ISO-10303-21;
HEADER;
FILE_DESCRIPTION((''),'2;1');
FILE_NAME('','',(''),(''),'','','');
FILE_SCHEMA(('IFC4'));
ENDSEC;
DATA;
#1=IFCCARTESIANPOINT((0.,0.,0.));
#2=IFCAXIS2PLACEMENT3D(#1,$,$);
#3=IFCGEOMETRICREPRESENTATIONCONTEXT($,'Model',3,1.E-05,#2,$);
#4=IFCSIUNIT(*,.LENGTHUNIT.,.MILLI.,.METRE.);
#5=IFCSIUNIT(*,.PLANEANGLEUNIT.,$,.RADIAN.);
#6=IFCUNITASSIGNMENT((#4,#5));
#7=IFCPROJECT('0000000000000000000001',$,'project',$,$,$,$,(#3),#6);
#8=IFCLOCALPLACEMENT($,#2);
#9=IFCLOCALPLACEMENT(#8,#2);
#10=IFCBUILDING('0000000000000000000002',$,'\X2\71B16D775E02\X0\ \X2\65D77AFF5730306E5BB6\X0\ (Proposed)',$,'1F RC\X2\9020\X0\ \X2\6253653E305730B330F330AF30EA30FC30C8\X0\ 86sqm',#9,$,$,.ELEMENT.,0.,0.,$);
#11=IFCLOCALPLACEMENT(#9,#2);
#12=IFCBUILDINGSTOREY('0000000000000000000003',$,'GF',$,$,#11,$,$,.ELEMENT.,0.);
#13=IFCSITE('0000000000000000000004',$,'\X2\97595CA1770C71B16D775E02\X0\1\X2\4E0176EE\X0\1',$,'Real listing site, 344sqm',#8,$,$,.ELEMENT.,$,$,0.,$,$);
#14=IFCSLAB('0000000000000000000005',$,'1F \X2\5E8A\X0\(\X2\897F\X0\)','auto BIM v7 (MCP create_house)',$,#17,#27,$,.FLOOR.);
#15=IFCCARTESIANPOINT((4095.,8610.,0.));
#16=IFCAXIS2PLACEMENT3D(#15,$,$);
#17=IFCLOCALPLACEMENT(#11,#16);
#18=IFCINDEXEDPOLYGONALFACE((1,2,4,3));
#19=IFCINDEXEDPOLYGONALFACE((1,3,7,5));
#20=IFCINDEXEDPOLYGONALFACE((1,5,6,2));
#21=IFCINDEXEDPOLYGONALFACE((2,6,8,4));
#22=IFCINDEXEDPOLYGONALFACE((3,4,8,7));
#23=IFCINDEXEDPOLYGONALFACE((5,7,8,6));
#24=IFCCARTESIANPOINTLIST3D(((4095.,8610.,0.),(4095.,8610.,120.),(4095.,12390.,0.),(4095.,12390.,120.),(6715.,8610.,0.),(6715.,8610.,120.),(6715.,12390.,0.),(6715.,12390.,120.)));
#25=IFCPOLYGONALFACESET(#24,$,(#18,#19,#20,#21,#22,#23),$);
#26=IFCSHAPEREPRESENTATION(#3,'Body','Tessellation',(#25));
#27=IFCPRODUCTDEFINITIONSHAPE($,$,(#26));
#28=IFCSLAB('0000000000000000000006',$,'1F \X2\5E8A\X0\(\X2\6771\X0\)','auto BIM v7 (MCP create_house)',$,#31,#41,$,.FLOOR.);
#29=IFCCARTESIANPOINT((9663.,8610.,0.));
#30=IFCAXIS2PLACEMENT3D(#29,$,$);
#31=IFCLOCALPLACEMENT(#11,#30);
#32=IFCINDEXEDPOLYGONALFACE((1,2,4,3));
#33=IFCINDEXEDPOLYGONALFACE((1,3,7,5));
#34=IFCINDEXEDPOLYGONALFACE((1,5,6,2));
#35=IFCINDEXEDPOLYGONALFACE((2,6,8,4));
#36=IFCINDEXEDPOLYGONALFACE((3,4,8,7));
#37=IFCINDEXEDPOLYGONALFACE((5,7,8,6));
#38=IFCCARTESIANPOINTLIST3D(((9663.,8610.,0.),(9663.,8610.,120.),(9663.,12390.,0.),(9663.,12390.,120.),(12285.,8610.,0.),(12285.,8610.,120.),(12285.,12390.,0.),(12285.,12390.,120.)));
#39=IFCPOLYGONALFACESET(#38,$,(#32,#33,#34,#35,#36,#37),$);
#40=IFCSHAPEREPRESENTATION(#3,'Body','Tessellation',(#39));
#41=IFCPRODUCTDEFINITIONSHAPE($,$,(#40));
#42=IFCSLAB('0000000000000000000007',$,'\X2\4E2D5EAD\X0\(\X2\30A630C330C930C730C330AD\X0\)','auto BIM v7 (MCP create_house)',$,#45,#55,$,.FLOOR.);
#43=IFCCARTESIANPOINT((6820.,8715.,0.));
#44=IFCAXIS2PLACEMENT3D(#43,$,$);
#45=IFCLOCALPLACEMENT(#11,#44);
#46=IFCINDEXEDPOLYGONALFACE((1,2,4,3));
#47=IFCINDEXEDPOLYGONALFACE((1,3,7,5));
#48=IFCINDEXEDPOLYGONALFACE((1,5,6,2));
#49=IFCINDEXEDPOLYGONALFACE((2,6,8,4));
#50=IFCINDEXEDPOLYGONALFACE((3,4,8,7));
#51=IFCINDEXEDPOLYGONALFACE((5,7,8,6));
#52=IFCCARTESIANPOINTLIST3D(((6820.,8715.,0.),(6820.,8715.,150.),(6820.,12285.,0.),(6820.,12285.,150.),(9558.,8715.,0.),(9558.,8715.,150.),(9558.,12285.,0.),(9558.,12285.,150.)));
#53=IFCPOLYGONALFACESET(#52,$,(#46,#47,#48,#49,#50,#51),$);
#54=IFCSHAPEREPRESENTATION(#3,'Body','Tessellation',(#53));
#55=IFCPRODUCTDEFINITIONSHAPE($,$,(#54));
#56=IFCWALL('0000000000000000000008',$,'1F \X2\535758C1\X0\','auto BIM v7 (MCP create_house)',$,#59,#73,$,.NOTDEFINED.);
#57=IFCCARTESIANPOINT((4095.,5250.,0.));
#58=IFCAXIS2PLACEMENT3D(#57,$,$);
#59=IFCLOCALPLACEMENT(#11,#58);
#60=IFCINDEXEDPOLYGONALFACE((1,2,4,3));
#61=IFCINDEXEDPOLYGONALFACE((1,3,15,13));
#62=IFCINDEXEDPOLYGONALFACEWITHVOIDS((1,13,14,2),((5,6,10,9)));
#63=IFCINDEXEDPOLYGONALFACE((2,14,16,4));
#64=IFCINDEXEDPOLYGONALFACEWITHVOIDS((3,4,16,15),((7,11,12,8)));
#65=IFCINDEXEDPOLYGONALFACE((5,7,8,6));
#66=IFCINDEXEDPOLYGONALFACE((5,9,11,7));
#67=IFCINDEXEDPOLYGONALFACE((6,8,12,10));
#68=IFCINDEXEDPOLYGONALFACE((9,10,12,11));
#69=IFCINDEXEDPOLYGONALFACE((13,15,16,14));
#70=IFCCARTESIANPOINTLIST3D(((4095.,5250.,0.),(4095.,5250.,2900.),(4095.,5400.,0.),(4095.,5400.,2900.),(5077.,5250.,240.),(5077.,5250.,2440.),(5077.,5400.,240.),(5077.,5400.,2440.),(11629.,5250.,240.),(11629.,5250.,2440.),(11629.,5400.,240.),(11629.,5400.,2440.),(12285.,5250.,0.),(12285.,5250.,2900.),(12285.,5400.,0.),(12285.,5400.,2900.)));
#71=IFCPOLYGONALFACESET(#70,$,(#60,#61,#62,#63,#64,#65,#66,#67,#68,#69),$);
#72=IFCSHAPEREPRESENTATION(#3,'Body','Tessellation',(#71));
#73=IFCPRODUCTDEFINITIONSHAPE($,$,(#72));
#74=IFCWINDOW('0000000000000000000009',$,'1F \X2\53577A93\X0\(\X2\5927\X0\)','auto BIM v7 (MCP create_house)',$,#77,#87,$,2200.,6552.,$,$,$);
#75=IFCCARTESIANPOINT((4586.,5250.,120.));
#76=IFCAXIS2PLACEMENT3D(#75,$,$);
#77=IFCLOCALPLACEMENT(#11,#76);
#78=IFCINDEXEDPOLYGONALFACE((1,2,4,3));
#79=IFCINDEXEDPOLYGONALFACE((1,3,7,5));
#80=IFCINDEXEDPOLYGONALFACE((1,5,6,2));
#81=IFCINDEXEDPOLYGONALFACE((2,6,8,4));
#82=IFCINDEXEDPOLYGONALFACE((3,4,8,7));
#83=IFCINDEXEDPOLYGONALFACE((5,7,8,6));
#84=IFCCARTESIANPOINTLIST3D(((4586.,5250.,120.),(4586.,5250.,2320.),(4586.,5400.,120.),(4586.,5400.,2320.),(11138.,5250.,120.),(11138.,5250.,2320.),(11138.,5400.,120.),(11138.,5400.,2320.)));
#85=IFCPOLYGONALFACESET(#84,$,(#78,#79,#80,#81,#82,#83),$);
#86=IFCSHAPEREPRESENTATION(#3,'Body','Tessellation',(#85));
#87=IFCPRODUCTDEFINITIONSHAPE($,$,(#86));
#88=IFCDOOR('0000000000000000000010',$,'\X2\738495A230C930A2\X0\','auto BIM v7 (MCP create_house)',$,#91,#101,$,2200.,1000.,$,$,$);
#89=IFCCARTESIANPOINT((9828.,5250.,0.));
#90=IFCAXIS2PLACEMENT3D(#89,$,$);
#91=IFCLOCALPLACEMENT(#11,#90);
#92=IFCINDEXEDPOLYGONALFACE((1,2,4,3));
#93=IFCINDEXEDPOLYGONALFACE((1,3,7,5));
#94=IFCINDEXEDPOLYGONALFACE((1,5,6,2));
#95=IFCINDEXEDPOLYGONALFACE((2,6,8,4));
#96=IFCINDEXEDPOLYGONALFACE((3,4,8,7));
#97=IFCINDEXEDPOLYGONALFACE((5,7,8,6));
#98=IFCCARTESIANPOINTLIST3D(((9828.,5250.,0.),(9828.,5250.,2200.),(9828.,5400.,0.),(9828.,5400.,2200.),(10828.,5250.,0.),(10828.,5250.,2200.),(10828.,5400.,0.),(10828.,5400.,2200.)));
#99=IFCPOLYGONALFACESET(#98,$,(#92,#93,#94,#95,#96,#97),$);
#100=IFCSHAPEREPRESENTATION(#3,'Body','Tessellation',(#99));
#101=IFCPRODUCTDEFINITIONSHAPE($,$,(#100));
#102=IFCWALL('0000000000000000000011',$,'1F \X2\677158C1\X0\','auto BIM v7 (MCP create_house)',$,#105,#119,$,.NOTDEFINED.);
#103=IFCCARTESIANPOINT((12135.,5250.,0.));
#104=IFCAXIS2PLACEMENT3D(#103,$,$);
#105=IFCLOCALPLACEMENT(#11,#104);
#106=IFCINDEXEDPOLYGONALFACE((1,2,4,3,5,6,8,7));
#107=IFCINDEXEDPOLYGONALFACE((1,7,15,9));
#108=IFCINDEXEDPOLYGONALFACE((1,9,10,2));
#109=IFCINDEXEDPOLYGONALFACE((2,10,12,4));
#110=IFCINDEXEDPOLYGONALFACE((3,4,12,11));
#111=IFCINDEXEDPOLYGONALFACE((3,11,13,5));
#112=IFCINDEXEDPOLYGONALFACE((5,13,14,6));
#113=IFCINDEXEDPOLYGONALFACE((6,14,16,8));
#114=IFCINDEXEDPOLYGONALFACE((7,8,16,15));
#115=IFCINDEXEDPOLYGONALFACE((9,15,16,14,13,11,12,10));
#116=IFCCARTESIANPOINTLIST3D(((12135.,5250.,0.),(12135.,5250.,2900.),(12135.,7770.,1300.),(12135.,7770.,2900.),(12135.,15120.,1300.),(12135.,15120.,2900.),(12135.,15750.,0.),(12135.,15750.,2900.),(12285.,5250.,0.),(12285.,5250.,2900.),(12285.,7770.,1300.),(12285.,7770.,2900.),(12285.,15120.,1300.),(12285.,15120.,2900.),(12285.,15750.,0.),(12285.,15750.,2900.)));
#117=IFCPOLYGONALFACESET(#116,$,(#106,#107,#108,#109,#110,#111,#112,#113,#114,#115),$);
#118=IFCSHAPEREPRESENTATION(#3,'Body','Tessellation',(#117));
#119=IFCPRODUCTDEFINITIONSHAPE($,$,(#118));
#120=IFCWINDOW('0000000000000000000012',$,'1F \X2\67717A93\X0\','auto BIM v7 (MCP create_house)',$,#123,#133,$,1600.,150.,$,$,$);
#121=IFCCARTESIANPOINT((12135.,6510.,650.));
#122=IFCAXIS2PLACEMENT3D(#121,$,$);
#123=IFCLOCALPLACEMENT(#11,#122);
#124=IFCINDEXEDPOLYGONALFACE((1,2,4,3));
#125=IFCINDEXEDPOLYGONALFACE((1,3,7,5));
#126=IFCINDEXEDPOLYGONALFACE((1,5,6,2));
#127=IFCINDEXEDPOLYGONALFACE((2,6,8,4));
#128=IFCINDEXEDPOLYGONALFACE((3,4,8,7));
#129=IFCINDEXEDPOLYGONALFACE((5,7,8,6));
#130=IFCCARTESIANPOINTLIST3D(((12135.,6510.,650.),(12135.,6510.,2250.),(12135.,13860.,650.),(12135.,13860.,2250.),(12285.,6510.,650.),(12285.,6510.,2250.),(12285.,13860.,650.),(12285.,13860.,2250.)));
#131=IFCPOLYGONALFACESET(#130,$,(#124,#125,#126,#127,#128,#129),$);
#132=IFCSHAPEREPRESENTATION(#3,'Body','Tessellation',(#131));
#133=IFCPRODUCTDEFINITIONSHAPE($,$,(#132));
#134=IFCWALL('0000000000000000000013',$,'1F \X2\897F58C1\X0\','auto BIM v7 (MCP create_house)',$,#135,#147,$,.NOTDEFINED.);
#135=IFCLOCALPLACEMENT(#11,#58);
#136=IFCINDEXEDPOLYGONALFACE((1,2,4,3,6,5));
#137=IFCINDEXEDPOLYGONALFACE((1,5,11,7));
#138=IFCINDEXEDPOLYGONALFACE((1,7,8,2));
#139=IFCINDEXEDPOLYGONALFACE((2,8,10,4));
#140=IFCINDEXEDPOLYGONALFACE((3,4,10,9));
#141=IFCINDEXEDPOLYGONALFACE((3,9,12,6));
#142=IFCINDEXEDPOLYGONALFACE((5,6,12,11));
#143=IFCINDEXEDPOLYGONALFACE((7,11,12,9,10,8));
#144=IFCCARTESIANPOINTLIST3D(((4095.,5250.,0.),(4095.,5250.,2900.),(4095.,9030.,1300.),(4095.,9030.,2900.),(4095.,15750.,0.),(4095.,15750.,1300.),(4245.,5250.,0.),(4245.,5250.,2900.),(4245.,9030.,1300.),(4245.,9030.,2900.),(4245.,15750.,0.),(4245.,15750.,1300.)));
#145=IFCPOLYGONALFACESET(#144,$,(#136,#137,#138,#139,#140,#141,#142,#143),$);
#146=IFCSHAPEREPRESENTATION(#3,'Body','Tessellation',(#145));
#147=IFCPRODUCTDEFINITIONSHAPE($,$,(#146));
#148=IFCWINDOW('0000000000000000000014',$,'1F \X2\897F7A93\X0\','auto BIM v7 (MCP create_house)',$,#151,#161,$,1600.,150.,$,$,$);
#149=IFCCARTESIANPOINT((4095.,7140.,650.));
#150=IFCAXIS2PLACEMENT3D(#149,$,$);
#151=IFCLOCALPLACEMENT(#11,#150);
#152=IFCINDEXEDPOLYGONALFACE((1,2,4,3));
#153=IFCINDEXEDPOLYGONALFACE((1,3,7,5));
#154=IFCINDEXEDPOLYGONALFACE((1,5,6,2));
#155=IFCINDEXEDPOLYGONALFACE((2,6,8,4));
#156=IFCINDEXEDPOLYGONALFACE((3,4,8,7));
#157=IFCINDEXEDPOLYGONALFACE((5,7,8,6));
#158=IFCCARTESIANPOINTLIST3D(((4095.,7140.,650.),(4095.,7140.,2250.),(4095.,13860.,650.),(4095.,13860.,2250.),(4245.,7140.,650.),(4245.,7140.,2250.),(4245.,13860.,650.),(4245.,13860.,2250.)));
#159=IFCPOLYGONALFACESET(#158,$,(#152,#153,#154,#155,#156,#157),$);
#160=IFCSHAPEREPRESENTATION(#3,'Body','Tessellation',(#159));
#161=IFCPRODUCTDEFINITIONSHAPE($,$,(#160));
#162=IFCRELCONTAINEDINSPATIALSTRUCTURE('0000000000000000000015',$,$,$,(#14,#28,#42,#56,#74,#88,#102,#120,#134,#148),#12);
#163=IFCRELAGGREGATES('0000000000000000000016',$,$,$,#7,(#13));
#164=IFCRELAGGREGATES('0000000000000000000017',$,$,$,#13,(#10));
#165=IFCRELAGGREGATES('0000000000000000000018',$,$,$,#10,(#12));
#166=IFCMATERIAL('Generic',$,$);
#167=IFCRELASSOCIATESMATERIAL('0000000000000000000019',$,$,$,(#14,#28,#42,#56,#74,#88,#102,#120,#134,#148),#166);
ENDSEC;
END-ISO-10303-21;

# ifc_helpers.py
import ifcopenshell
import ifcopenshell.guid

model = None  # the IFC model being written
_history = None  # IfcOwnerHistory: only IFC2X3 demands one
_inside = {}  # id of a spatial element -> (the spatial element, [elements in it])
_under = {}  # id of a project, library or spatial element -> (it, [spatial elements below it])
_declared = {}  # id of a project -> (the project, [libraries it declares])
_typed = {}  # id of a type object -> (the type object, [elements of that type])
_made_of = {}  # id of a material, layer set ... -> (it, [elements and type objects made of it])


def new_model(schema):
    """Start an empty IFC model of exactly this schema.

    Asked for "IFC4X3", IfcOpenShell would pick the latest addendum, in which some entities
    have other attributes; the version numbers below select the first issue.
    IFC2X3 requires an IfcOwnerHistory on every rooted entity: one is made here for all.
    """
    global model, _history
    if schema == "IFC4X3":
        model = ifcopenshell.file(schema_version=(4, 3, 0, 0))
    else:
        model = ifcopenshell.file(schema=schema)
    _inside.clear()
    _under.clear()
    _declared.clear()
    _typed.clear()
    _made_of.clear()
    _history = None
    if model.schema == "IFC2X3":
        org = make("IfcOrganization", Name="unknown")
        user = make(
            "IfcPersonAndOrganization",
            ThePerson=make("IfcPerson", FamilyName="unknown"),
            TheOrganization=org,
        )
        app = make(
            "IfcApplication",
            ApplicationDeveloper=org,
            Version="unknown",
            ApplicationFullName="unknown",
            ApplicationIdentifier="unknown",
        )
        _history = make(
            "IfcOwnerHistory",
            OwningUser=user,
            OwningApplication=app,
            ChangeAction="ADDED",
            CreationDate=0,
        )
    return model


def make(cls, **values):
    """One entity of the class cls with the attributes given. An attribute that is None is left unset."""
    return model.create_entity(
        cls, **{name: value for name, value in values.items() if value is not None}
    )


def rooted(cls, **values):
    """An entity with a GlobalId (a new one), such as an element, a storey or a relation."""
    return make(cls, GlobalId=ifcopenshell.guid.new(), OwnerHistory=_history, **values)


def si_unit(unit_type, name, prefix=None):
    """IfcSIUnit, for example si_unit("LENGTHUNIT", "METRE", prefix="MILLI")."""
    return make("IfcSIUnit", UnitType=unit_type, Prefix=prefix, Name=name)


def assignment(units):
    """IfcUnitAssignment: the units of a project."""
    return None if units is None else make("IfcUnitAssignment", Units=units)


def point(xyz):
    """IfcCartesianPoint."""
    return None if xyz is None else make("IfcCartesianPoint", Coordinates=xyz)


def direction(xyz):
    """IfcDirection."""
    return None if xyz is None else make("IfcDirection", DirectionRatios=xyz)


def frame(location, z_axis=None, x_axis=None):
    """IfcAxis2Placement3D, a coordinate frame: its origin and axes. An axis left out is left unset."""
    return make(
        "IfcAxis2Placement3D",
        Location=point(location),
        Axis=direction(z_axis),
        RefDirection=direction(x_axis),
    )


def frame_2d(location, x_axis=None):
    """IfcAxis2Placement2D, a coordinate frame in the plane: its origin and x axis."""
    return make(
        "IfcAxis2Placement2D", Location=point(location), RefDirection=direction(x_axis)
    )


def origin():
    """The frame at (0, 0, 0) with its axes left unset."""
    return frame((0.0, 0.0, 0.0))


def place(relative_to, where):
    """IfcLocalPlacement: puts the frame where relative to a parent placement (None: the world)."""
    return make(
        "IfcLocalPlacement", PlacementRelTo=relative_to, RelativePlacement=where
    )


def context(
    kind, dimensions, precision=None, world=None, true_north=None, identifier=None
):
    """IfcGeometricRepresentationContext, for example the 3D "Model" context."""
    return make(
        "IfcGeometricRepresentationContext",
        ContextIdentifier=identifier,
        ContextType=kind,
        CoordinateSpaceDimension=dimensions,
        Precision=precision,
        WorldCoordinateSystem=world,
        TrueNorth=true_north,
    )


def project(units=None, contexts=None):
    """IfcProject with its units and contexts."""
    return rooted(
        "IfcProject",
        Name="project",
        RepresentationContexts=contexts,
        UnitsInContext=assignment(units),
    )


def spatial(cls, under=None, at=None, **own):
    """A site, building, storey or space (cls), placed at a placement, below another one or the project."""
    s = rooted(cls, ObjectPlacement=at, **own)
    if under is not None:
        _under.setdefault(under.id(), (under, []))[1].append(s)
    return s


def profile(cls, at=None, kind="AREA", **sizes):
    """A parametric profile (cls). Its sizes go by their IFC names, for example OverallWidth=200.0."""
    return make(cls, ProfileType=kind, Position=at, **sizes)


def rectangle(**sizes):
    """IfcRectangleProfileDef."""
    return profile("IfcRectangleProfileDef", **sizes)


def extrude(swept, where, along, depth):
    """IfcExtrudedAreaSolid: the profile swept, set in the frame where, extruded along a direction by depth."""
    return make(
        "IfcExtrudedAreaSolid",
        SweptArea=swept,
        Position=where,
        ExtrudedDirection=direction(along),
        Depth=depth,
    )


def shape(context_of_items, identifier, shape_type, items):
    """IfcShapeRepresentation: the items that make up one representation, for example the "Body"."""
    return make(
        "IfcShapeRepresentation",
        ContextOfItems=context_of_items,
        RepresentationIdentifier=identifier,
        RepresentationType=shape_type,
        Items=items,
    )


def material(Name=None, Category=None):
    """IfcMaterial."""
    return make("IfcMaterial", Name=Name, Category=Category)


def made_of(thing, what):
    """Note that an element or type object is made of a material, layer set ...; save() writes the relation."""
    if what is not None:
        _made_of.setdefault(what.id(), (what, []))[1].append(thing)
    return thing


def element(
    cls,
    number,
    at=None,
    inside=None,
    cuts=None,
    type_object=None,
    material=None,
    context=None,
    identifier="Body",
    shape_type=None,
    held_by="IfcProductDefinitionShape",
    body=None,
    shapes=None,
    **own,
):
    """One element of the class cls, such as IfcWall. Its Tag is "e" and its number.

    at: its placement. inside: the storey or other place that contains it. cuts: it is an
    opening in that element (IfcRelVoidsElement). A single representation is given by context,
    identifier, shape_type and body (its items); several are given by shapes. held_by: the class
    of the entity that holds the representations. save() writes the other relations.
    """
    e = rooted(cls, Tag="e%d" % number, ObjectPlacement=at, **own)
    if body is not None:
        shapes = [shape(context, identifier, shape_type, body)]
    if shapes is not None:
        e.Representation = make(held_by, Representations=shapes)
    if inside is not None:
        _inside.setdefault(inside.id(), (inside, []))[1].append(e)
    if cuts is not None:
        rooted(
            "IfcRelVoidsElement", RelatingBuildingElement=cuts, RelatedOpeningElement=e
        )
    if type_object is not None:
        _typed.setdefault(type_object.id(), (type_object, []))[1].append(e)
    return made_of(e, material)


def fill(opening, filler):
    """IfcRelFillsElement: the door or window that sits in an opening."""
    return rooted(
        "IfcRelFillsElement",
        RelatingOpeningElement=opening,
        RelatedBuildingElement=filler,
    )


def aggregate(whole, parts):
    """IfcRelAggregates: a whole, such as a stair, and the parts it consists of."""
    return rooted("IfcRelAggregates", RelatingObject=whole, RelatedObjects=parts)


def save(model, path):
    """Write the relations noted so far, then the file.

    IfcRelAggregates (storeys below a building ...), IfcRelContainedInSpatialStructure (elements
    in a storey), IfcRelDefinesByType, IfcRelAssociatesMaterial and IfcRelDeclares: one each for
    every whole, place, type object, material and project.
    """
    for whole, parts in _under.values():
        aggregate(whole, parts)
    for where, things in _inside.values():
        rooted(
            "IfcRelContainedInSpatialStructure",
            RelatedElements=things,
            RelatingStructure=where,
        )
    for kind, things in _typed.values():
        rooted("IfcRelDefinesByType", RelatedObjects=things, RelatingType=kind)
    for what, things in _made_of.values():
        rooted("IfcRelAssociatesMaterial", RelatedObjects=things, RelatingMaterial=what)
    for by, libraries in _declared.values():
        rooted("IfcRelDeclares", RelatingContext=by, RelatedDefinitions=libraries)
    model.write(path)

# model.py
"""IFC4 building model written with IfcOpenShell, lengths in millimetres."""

from ifc_helpers import new_model, si_unit, frame, frame_2d, origin, place, context, project, spatial, rectangle, extrude, material, element, fill, save


model = new_model("IFC4")

# Units and contexts
model_context = context("Model", 3, precision=1e-05, world=origin())
ifc_project = project(units=[si_unit("LENGTHUNIT", "METRE", prefix="MILLI"), si_unit("PLANEANGLEUNIT", "RADIAN")], contexts=[model_context])

# Site, building, storey
site_placement = place(None, origin())
site = spatial("IfcSite", under=ifc_project, at=site_placement, Name="静岡県熱海市1丁目1", ObjectType="Real listing site, 344sqm", CompositionType="ELEMENT", RefElevation=0.0)
building_placement = place(site_placement, origin())
building = spatial("IfcBuilding", under=site, at=building_placement, Name="熱海市 旗竿地の家 (Proposed)", ObjectType="1F RC造 打放しコンクリート 86sqm", CompositionType="ELEMENT", ElevationOfRefHeight=0.0, ElevationOfTerrain=0.0)
storey_placement = place(building_placement, origin())
storey = spatial("IfcBuildingStorey", under=building, at=storey_placement, Name="GF", CompositionType="ELEMENT", Elevation=0.0)

# Slabs
ifc_material = material(Name="Generic")
slab_1_placement = place(storey_placement, frame((4095.0, 8610.0, 0.0)))
element("IfcSlab", 1, at=slab_1_placement, inside=storey, material=ifc_material, Name="1F 床(西)", Description="auto BIM v7 (MCP create_house)", PredefinedType="FLOOR", context=model_context, shape_type="SweptSolid", body=[
    extrude(rectangle(XDim=2620.0, YDim=3780.0, at=frame_2d((1310.0, 1890.0))), frame((4095.0, 8610.0, 0.0)), (0.0, 0.0, 1.0), 120.0),
])
slab_2_placement = place(storey_placement, frame((9663.0, 8610.0, 0.0)))
element("IfcSlab", 2, at=slab_2_placement, inside=storey, material=ifc_material, Name="1F 床(東)", Description="auto BIM v7 (MCP create_house)", PredefinedType="FLOOR", context=model_context, shape_type="SweptSolid", body=[
    extrude(rectangle(XDim=2622.0, YDim=3780.0, at=frame_2d((1311.0, 1890.0))), frame((9663.0, 8610.0, 0.0)), (0.0, 0.0, 1.0), 120.0),
])
slab_3_placement = place(storey_placement, frame((6820.0, 8715.0, 0.0)))
element("IfcSlab", 3, at=slab_3_placement, inside=storey, material=ifc_material, Name="中庭(ウッドデッキ)", Description="auto BIM v7 (MCP create_house)", PredefinedType="FLOOR", context=model_context, shape_type="SweptSolid", body=[
    extrude(rectangle(XDim=2738.0, YDim=3570.0, at=frame_2d((1369.0, 1785.0))), frame((6820.0, 8715.0, 0.0)), (0.0, 0.0, 1.0), 150.0),
])

# Wall, openings, window, door
wall_1_placement = place(storey_placement, frame((4095.0, 5250.0, 0.0)))
wall_1 = element("IfcWall", 4, at=wall_1_placement, inside=storey, material=ifc_material, Name="1F 南壁", Description="auto BIM v7 (MCP create_house)", PredefinedType="NOTDEFINED", context=model_context, shape_type="SweptSolid", body=[
    extrude(rectangle(XDim=8190.0, YDim=150.0, at=frame_2d((4095.0, 75.0))), frame((4095.0, 5250.0, 0.0)), (0.0, 0.0, 1.0), 2900.0),
])
opening_1_placement = place(storey_placement, frame((4586.0, 5250.0, 120.0)))
opening_1 = element("IfcOpeningElement", 5, at=opening_1_placement, cuts=wall_1, PredefinedType="NOTDEFINED", context=model_context, shape_type="SweptSolid", body=[
    extrude(rectangle(XDim=6552.0, YDim=150.0, at=frame_2d((3276.0, 75.0))), frame((4586.0, 5250.0, 120.0)), (0.0, 0.0, 1.0), 2200.0),
])
opening_2_placement = place(storey_placement, frame((9828.0, 5250.0, 0.0)))
opening_2 = element("IfcOpeningElement", 6, at=opening_2_placement, cuts=wall_1, PredefinedType="NOTDEFINED", context=model_context, shape_type="SweptSolid", body=[
    extrude(rectangle(XDim=1000.0, YDim=150.0, at=frame_2d((500.0, 75.0))), frame((9828.0, 5250.0, 0.0)), (0.0, 0.0, 1.0), 2200.0),
])
window_1_placement = place(storey_placement, frame((4586.0, 5250.0, 120.0)))
window_1 = element("IfcWindow", 7, at=window_1_placement, inside=storey, material=ifc_material, Name="1F 南窓(大)", Description="auto BIM v7 (MCP create_house)", OverallHeight=2200.0, OverallWidth=6552.0, context=model_context, shape_type="SweptSolid", body=[
    extrude(rectangle(XDim=6552.0, YDim=150.0, at=frame_2d((3276.0, 75.0))), frame((4586.0, 5250.0, 120.0)), (0.0, 0.0, 1.0), 2200.0),
])
fill(opening_1, window_1)
door_placement = place(storey_placement, frame((9828.0, 5250.0, 0.0)))
door = element("IfcDoor", 8, at=door_placement, inside=storey, material=ifc_material, Name="玄関ドア", Description="auto BIM v7 (MCP create_house)", OverallHeight=2200.0, OverallWidth=1000.0, context=model_context, shape_type="SweptSolid", body=[
    extrude(rectangle(XDim=1000.0, YDim=150.0, at=frame_2d((500.0, 75.0))), frame((9828.0, 5250.0, 0.0)), (0.0, 0.0, 1.0), 2200.0),
])
fill(opening_2, door)

# Walls, openings, windows
wall_2_placement = place(storey_placement, frame((12135.0, 5250.0, 0.0)))
wall_2 = element("IfcWall", 9, at=wall_2_placement, inside=storey, material=ifc_material, Name="1F 東壁", Description="auto BIM v7 (MCP create_house)", PredefinedType="NOTDEFINED", context=model_context, shape_type="SweptSolid", body=[
    extrude(rectangle(XDim=150.0, YDim=10500.0, at=frame_2d((75.0, 5250.0))), frame((12135.0, 5250.0, 0.0)), (0.0, 0.0, 1.0), 2900.0),
])
opening_3_placement = place(storey_placement, frame((12135.0, 6510.0, 650.0)))
opening_3 = element("IfcOpeningElement", 10, at=opening_3_placement, cuts=wall_2, PredefinedType="NOTDEFINED", context=model_context, shape_type="SweptSolid", body=[
    extrude(rectangle(XDim=150.0, YDim=7350.0, at=frame_2d((75.0, 3675.0))), frame((12135.0, 6510.0, 650.0)), (0.0, 0.0, 1.0), 1600.0),
])
window_2_placement = place(storey_placement, frame((12135.0, 6510.0, 650.0)))
window_2 = element("IfcWindow", 11, at=window_2_placement, inside=storey, material=ifc_material, Name="1F 東窓", Description="auto BIM v7 (MCP create_house)", OverallHeight=1600.0, OverallWidth=150.0, context=model_context, shape_type="SweptSolid", body=[
    extrude(rectangle(XDim=150.0, YDim=7350.0, at=frame_2d((75.0, 3675.0))), frame((12135.0, 6510.0, 650.0)), (0.0, 0.0, 1.0), 1600.0),
])
fill(opening_3, window_2)
wall_3_placement = place(storey_placement, frame((4095.0, 5250.0, 0.0)))
wall_3 = element("IfcWall", 12, at=wall_3_placement, inside=storey, material=ifc_material, Name="1F 西壁", Description="auto BIM v7 (MCP create_house)", PredefinedType="NOTDEFINED", context=model_context, shape_type="SweptSolid", body=[
    extrude(rectangle(XDim=150.0, YDim=10500.0, at=frame_2d((75.0, 5250.0))), frame((4095.0, 5250.0, 0.0)), (0.0, 0.0, 1.0), 2900.0),
])
opening_4_placement = place(storey_placement, frame((4095.0, 7140.0, 650.0)))
opening_4 = element("IfcOpeningElement", 13, at=opening_4_placement, cuts=wall_3, PredefinedType="NOTDEFINED", context=model_context, shape_type="SweptSolid", body=[
    extrude(rectangle(XDim=150.0, YDim=6720.0, at=frame_2d((75.0, 3360.0))), frame((4095.0, 7140.0, 650.0)), (0.0, 0.0, 1.0), 1600.0),
])
window_3_placement = place(storey_placement, frame((4095.0, 7140.0, 650.0)))
window_3 = element("IfcWindow", 14, at=window_3_placement, inside=storey, material=ifc_material, Name="1F 西窓", Description="auto BIM v7 (MCP create_house)", OverallHeight=1600.0, OverallWidth=150.0, context=model_context, shape_type="SweptSolid", body=[
    extrude(rectangle(XDim=150.0, YDim=6720.0, at=frame_2d((75.0, 3360.0))), frame((4095.0, 7140.0, 650.0)), (0.0, 0.0, 1.0), 1600.0),
])
fill(opening_4, window_3)

save(model, "model.ifc")
